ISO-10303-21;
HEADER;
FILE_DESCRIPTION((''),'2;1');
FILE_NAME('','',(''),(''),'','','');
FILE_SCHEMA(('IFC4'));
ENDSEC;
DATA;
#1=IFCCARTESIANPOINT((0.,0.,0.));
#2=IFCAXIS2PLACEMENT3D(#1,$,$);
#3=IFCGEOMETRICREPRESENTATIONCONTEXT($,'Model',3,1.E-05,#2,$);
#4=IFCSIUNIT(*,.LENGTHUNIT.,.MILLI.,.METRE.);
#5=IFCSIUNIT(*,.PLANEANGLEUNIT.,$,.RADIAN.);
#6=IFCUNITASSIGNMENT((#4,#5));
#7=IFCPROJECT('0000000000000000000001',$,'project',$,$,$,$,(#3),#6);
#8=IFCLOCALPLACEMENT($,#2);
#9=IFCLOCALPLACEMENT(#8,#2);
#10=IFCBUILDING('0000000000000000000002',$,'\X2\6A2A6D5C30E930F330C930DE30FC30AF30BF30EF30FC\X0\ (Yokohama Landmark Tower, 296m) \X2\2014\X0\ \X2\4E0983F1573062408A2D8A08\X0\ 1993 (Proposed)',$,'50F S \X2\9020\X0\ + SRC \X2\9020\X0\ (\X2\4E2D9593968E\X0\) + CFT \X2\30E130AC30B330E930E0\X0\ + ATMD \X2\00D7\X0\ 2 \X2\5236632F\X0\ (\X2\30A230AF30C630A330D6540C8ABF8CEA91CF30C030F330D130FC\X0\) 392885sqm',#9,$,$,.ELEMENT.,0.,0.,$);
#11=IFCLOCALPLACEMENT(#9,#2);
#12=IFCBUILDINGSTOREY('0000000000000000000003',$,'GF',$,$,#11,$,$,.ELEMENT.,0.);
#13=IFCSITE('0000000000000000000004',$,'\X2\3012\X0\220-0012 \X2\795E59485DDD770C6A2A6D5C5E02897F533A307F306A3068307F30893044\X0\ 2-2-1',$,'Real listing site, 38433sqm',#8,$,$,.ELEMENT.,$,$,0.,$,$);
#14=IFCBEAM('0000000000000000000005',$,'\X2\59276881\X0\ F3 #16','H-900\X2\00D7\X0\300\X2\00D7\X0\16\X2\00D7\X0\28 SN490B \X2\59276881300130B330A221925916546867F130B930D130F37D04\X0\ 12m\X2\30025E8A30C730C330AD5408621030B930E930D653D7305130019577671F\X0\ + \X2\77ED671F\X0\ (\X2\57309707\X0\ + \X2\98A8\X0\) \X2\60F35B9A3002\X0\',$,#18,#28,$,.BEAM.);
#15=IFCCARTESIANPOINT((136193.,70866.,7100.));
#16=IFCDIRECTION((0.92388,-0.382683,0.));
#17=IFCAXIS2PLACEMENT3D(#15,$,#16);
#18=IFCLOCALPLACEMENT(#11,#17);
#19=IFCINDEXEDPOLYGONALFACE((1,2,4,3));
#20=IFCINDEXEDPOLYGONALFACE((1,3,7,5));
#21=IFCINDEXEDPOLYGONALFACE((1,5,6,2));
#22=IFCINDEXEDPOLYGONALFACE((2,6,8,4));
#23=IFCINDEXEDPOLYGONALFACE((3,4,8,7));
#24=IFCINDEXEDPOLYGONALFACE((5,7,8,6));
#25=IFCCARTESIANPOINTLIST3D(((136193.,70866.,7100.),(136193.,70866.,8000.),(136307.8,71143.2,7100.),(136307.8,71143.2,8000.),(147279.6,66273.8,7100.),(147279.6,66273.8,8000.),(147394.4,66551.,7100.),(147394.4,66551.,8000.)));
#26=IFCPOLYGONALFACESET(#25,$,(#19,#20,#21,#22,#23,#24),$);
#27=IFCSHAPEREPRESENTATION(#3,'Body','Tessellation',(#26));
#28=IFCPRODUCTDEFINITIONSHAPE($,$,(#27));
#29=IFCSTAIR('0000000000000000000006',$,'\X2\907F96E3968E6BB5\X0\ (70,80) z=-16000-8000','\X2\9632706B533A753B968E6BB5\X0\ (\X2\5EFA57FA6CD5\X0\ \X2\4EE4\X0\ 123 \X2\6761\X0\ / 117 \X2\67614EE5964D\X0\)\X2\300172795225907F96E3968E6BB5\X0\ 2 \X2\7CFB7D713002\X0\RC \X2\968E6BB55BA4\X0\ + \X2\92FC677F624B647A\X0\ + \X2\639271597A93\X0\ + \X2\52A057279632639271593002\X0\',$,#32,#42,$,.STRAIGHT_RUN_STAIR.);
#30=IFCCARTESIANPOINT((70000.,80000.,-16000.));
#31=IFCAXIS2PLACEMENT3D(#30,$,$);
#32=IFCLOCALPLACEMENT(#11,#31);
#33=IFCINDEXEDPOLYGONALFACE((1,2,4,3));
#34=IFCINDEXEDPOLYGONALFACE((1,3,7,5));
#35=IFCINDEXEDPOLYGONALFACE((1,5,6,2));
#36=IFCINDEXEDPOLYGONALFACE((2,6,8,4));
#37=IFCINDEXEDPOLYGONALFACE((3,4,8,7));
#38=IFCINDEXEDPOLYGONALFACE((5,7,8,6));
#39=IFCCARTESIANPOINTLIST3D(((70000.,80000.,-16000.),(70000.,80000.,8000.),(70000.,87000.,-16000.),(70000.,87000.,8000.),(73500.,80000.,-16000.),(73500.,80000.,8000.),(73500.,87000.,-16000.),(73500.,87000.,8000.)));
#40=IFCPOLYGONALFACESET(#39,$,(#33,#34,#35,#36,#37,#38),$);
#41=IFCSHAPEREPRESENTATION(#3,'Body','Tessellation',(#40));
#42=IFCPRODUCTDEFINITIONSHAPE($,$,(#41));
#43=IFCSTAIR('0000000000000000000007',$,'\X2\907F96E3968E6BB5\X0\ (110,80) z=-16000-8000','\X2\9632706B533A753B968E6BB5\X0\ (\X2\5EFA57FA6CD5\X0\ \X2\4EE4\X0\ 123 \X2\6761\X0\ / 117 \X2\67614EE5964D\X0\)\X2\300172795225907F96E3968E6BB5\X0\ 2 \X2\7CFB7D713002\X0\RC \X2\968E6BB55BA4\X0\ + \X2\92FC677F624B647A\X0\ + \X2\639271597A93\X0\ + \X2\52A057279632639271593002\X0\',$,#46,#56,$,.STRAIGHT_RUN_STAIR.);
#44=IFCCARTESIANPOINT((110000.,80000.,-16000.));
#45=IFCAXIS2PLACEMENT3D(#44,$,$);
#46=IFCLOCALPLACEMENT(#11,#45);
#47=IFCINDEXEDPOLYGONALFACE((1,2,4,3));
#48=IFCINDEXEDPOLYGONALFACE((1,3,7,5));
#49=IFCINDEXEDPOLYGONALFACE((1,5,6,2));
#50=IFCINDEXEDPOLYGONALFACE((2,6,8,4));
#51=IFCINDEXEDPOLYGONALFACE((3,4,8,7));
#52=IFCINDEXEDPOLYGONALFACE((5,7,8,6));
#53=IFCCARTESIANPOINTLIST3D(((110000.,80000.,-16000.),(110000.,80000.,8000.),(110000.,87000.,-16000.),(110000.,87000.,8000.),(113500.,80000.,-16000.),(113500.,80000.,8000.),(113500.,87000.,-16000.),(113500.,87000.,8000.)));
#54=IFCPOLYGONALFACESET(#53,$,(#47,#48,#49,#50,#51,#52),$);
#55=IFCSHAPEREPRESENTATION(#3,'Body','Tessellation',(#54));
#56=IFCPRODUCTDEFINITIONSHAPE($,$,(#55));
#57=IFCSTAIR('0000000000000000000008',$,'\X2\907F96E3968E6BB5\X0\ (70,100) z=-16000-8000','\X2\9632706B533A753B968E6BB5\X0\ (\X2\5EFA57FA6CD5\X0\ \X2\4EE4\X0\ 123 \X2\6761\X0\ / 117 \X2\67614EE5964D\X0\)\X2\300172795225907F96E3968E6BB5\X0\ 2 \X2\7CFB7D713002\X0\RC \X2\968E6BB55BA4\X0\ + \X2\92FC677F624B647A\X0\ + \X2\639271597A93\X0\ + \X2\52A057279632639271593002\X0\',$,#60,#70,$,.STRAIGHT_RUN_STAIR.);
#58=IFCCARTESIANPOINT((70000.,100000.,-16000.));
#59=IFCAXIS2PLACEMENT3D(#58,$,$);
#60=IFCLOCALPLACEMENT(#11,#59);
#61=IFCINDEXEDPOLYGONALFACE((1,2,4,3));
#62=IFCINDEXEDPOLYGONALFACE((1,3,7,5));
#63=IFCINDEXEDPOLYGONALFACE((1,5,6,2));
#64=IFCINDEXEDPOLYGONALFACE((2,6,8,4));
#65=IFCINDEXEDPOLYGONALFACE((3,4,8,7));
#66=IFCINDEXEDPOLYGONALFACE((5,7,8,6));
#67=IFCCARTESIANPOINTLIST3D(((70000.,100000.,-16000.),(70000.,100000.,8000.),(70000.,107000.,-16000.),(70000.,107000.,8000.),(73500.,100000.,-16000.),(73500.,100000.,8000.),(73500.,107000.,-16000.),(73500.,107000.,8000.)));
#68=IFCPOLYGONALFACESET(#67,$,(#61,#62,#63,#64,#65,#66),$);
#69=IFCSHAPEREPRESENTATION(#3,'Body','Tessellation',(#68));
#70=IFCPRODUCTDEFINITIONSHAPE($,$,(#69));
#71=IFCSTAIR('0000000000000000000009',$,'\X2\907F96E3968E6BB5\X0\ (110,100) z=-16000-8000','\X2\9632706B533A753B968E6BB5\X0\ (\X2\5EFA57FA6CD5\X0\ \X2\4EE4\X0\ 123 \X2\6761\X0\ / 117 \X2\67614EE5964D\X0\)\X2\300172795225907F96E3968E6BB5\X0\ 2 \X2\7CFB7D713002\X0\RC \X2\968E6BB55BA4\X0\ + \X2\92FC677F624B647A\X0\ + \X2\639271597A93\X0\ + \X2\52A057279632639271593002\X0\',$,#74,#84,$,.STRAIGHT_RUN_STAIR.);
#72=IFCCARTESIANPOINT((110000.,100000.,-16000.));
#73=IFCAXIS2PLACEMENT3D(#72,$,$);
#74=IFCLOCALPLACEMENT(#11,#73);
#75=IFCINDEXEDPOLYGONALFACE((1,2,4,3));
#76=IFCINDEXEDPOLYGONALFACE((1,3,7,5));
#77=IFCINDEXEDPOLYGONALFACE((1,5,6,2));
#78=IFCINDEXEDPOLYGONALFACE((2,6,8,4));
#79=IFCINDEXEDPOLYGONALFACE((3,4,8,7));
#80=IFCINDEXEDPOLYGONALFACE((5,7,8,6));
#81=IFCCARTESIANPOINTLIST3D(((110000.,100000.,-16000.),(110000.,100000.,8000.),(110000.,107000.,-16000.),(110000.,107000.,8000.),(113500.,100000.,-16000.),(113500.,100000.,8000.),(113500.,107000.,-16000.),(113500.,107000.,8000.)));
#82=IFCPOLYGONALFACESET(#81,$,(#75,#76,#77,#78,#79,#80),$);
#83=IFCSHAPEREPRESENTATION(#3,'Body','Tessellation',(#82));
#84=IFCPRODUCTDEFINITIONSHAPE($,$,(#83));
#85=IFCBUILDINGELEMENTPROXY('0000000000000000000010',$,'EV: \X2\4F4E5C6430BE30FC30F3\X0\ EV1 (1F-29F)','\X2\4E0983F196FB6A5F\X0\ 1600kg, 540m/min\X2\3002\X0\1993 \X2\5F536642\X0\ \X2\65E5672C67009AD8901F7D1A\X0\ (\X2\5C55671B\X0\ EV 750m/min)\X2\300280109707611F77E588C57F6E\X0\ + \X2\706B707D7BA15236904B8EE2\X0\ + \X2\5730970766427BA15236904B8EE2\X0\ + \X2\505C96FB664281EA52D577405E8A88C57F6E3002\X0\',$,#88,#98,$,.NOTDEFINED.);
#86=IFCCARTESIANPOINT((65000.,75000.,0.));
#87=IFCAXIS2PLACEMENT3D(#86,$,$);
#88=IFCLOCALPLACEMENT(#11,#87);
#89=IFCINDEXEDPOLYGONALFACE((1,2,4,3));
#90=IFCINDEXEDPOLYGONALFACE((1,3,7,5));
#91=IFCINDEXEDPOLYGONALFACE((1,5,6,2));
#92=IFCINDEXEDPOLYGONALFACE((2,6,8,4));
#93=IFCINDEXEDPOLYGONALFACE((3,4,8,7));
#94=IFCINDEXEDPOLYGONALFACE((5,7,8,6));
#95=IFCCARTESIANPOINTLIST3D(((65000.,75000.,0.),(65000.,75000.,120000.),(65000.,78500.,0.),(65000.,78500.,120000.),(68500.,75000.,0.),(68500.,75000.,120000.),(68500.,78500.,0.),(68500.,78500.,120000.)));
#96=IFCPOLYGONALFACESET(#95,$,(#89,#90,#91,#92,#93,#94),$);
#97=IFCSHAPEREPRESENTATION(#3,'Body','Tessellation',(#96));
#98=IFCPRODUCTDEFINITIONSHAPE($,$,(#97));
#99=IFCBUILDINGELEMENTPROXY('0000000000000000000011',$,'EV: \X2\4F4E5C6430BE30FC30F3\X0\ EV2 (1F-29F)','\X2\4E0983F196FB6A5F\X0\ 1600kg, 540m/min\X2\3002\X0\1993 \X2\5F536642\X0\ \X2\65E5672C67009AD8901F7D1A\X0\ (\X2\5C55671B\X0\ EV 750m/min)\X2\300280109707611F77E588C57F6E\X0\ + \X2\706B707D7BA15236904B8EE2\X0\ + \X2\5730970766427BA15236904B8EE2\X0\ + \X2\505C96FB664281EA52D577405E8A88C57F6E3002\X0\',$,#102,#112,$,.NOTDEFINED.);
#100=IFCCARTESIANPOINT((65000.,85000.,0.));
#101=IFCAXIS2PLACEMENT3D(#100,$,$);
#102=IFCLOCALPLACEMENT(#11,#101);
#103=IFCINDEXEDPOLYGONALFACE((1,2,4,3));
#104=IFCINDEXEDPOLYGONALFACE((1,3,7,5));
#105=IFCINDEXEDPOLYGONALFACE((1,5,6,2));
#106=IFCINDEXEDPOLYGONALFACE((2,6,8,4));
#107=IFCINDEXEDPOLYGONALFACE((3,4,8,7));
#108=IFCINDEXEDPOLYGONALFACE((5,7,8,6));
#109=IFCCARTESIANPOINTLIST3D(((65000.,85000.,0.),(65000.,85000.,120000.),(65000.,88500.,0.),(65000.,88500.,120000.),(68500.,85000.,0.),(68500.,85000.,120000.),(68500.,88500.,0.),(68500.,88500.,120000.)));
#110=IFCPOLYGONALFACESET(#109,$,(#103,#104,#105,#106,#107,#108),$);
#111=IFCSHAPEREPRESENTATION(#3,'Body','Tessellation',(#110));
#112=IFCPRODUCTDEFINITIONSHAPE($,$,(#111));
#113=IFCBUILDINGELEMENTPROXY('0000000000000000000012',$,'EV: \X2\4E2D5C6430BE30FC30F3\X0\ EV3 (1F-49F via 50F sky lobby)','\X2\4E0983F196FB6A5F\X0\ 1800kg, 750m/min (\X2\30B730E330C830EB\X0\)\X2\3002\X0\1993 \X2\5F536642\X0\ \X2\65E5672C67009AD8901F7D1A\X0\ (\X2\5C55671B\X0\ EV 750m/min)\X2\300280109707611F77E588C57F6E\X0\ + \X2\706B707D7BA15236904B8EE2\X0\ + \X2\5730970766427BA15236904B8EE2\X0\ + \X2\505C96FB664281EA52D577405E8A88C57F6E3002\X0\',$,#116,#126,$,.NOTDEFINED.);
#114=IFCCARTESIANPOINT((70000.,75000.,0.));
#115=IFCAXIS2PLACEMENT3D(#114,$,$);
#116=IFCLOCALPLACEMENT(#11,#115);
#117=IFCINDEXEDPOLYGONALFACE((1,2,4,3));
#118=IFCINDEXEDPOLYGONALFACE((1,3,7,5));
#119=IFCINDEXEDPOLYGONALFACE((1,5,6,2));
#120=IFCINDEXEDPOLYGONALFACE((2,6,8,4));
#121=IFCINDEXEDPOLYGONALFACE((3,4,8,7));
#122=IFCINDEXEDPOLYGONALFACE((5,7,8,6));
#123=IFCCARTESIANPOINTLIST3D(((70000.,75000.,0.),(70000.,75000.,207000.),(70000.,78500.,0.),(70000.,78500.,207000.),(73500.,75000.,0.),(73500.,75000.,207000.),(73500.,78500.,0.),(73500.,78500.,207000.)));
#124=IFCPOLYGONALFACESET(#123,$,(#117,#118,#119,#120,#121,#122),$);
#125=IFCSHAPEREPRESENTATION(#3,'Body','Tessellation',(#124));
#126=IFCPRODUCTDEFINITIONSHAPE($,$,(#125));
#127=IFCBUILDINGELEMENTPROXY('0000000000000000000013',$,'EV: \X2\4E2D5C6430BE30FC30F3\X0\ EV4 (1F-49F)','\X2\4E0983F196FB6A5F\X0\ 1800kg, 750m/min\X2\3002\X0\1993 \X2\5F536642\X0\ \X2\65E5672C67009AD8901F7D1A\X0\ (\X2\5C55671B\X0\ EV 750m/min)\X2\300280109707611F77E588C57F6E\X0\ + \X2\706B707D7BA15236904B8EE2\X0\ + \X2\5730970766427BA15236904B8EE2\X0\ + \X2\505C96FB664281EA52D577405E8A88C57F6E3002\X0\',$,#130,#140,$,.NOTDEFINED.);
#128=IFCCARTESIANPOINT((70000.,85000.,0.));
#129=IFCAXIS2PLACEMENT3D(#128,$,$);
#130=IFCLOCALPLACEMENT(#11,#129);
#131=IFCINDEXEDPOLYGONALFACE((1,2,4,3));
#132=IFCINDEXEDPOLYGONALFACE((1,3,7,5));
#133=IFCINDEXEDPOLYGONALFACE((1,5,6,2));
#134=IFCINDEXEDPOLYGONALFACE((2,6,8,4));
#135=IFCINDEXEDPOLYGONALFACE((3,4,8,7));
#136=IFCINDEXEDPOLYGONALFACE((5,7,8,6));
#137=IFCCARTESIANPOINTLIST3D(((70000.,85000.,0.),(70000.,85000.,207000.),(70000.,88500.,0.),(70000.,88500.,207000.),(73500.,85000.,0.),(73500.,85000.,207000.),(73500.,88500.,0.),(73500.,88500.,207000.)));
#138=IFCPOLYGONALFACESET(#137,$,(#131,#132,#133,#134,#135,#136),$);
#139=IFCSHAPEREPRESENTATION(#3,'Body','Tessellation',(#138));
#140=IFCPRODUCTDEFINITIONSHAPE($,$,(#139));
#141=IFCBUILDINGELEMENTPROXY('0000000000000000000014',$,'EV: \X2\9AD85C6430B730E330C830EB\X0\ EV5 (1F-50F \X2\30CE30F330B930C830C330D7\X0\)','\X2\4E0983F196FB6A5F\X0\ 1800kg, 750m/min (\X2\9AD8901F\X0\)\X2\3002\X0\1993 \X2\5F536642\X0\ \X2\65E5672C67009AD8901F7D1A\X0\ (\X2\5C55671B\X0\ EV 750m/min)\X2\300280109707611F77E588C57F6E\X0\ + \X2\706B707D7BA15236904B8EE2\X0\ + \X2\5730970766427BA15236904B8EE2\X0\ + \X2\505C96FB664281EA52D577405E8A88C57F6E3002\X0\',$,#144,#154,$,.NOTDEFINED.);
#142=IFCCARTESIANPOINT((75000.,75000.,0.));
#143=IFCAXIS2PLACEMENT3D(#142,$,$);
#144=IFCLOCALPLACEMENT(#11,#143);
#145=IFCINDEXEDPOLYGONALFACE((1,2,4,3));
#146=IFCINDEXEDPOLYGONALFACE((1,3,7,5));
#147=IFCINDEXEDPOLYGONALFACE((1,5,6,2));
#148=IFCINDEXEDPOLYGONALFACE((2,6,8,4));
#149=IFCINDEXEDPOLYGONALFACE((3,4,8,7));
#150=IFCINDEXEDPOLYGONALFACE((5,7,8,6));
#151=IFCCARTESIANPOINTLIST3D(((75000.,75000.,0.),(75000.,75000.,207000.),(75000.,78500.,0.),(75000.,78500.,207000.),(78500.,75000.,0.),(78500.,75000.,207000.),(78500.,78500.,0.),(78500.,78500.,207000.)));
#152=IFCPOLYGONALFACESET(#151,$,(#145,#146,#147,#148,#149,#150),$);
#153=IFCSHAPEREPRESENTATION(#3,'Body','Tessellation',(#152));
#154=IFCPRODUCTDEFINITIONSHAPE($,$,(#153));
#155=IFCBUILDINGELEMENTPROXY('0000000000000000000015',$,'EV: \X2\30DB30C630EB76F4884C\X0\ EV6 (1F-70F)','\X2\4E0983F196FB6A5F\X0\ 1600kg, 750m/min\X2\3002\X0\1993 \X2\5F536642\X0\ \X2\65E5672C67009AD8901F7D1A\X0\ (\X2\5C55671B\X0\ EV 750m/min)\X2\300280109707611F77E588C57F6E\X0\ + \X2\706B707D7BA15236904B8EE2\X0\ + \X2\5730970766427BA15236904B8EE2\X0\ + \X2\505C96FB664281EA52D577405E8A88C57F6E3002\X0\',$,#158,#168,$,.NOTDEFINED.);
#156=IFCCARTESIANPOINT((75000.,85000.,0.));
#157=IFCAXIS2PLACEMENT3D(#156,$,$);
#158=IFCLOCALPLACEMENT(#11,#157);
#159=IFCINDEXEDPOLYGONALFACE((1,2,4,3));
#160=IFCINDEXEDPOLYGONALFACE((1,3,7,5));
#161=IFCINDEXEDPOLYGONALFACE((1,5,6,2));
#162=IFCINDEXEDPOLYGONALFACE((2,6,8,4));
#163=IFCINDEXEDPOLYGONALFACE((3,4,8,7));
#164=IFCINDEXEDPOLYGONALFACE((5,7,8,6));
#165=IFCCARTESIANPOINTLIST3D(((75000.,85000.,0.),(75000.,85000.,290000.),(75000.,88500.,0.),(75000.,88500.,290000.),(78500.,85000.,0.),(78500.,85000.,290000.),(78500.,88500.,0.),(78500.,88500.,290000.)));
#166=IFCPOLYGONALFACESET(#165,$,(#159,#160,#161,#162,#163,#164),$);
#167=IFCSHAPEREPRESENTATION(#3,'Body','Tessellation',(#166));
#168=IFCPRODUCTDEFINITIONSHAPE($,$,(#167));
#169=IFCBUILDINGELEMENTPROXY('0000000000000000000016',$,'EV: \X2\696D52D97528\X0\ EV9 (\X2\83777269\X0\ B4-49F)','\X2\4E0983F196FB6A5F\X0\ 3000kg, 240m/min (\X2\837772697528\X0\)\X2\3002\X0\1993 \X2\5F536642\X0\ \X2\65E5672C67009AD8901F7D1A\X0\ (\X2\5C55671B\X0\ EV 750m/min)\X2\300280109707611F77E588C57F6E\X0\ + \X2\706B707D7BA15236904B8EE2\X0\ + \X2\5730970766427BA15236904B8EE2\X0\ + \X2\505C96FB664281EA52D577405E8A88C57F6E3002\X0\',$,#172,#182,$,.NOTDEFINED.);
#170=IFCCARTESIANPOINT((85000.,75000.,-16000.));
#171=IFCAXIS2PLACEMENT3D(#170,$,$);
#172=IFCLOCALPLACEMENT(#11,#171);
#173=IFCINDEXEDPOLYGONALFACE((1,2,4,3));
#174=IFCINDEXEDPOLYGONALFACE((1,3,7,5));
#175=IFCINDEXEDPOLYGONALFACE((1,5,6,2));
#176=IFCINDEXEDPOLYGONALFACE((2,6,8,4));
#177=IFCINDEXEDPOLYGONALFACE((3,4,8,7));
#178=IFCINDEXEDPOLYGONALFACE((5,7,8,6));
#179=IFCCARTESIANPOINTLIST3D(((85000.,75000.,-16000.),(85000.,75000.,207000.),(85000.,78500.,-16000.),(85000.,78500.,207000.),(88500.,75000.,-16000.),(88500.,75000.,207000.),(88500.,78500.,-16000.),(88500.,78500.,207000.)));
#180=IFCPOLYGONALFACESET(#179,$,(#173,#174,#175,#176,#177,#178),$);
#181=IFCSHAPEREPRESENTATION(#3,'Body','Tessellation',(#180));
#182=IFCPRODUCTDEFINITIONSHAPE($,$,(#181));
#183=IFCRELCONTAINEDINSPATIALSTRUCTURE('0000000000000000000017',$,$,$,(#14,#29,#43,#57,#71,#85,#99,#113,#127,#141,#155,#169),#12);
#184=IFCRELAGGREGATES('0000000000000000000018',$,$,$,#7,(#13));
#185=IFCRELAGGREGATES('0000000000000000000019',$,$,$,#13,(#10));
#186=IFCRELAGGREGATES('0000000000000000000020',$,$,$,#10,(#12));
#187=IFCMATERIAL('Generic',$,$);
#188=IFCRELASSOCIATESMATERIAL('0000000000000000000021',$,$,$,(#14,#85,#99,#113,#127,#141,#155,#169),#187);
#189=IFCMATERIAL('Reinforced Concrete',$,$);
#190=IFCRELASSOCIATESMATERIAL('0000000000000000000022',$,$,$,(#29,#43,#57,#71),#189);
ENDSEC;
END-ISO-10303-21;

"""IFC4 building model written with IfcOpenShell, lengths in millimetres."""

from ifc_helpers import new_model, si_unit, frame, frame_2d, origin, place, context, project, spatial, rectangle, extrude, material, element, save


model = new_model("IFC4")

# Units and contexts
model_context = context("Model", 3, precision=1e-05, world=origin())
ifc_project = project(units=[si_unit("LENGTHUNIT", "METRE", prefix="MILLI"), si_unit("PLANEANGLEUNIT", "RADIAN")], contexts=[model_context])

# Site, building, storey
site_placement = place(None, origin())
site = spatial("IfcSite", under=ifc_project, at=site_placement, Name="〒220-0012 神奈川県横浜市西区みなとみらい 2-2-1", ObjectType="Real listing site, 38433sqm", CompositionType="ELEMENT", RefElevation=0.0)
building_placement = place(site_placement, origin())
building = spatial("IfcBuilding", under=site, at=building_placement, Name="横浜ランドマークタワー (Yokohama Landmark Tower, 296m) — 三菱地所設計 1993 (Proposed)", ObjectType="50F S 造 + SRC 造 (中間階) + CFT メガコラム + ATMD × 2 制振 (アクティブ同調質量ダンパー) 392885sqm", CompositionType="ELEMENT", ElevationOfRefHeight=0.0, ElevationOfTerrain=0.0)
storey_placement = place(building_placement, origin())
storey = spatial("IfcBuildingStorey", under=building, at=storey_placement, Name="GF", CompositionType="ELEMENT", Elevation=0.0)

# Shared definitions
ifc_material_1 = material(Name="Reinforced Concrete")

# Beam
ifc_material_2 = material(Name="Generic")
beam_1_placement = place(storey_placement, frame((136193.0, 70866.0, 7100.0), x_axis=(0.92388, -0.382683, 0.0)))
element("IfcBeam", 1, at=beam_1_placement, inside=storey, material=ifc_material_2, Name="大梁 F3 #16", Description="H-900×300×16×28 SN490B 大梁、コア→外周柱スパン約 12m。床デッキ合成スラブ受け、長期 + 短期 (地震 + 風) 想定。", PredefinedType="BEAM", context=model_context, shape_type="SweptSolid", body=[
    extrude(rectangle(XDim=12000.0, YDim=300.0, at=frame_2d((6000.0, 150.0))), frame((136193.0, 70866.0, 7100.0), x_axis=(0.92388, -0.382683, 0.0)), (0.0, 0.0, 1.0), 900.0),
])

# Stairs
stair_1_placement = place(storey_placement, frame((70000.0, 80000.0, -16000.0)))
element("IfcStair", 2, at=stair_1_placement, inside=storey, material=ifc_material_1, Name="避難階段 (70,80) z=-16000-8000", Description="防火区画階段 (建基法 令 123 条 / 117 条以降)、特別避難階段 2 系統。RC 階段室 + 鋼板手摺 + 排煙窓 + 加圧防排煙。", PredefinedType="STRAIGHT_RUN_STAIR", context=model_context, shape_type="SweptSolid", body=[
    extrude(rectangle(XDim=3500.0, YDim=7000.0, at=frame_2d((1750.0, 3500.0))), frame((70000.0, 80000.0, -16000.0)), (0.0, 0.0, 1.0), 24000.0),
])
stair_2_placement = place(storey_placement, frame((110000.0, 80000.0, -16000.0)))
element("IfcStair", 3, at=stair_2_placement, inside=storey, material=ifc_material_1, Name="避難階段 (110,80) z=-16000-8000", Description="防火区画階段 (建基法 令 123 条 / 117 条以降)、特別避難階段 2 系統。RC 階段室 + 鋼板手摺 + 排煙窓 + 加圧防排煙。", PredefinedType="STRAIGHT_RUN_STAIR", context=model_context, shape_type="SweptSolid", body=[
    extrude(rectangle(XDim=3500.0, YDim=7000.0, at=frame_2d((1750.0, 3500.0))), frame((110000.0, 80000.0, -16000.0)), (0.0, 0.0, 1.0), 24000.0),
])
stair_3_placement = place(storey_placement, frame((70000.0, 100000.0, -16000.0)))
element("IfcStair", 4, at=stair_3_placement, inside=storey, material=ifc_material_1, Name="避難階段 (70,100) z=-16000-8000", Description="防火区画階段 (建基法 令 123 条 / 117 条以降)、特別避難階段 2 系統。RC 階段室 + 鋼板手摺 + 排煙窓 + 加圧防排煙。", PredefinedType="STRAIGHT_RUN_STAIR", context=model_context, shape_type="SweptSolid", body=[
    extrude(rectangle(XDim=3500.0, YDim=7000.0, at=frame_2d((1750.0, 3500.0))), frame((70000.0, 100000.0, -16000.0)), (0.0, 0.0, 1.0), 24000.0),
])
stair_4_placement = place(storey_placement, frame((110000.0, 100000.0, -16000.0)))
element("IfcStair", 5, at=stair_4_placement, inside=storey, material=ifc_material_1, Name="避難階段 (110,100) z=-16000-8000", Description="防火区画階段 (建基法 令 123 条 / 117 条以降)、特別避難階段 2 系統。RC 階段室 + 鋼板手摺 + 排煙窓 + 加圧防排煙。", PredefinedType="STRAIGHT_RUN_STAIR", context=model_context, shape_type="SweptSolid", body=[
    extrude(rectangle(XDim=3500.0, YDim=7000.0, at=frame_2d((1750.0, 3500.0))), frame((110000.0, 100000.0, -16000.0)), (0.0, 0.0, 1.0), 24000.0),
])

# Building element proxies
proxy_1_placement = place(storey_placement, frame((65000.0, 75000.0, 0.0)))
element("IfcBuildingElementProxy", 6, at=proxy_1_placement, inside=storey, material=ifc_material_2, Name="EV: 低層ゾーン EV1 (1F-29F)", Description="三菱電機 1600kg, 540m/min。1993 当時 日本最高速級 (展望 EV 750m/min)。耐震感知装置 + 火災管制運転 + 地震時管制運転 + 停電時自動着床装置。", PredefinedType="NOTDEFINED", context=model_context, shape_type="SweptSolid", body=[
    extrude(rectangle(XDim=3500.0, YDim=3500.0, at=frame_2d((1750.0, 1750.0))), frame((65000.0, 75000.0, 0.0)), (0.0, 0.0, 1.0), 120000.0),
])
proxy_2_placement = place(storey_placement, frame((65000.0, 85000.0, 0.0)))
element("IfcBuildingElementProxy", 7, at=proxy_2_placement, inside=storey, material=ifc_material_2, Name="EV: 低層ゾーン EV2 (1F-29F)", Description="三菱電機 1600kg, 540m/min。1993 当時 日本最高速級 (展望 EV 750m/min)。耐震感知装置 + 火災管制運転 + 地震時管制運転 + 停電時自動着床装置。", PredefinedType="NOTDEFINED", context=model_context, shape_type="SweptSolid", body=[
    extrude(rectangle(XDim=3500.0, YDim=3500.0, at=frame_2d((1750.0, 1750.0))), frame((65000.0, 85000.0, 0.0)), (0.0, 0.0, 1.0), 120000.0),
])
proxy_3_placement = place(storey_placement, frame((70000.0, 75000.0, 0.0)))
element("IfcBuildingElementProxy", 8, at=proxy_3_placement, inside=storey, material=ifc_material_2, Name="EV: 中層ゾーン EV3 (1F-49F via 50F sky lobby)", Description="三菱電機 1800kg, 750m/min (シャトル)。1993 当時 日本最高速級 (展望 EV 750m/min)。耐震感知装置 + 火災管制運転 + 地震時管制運転 + 停電時自動着床装置。", PredefinedType="NOTDEFINED", context=model_context, shape_type="SweptSolid", body=[
    extrude(rectangle(XDim=3500.0, YDim=3500.0, at=frame_2d((1750.0, 1750.0))), frame((70000.0, 75000.0, 0.0)), (0.0, 0.0, 1.0), 207000.0),
])
proxy_4_placement = place(storey_placement, frame((70000.0, 85000.0, 0.0)))
element("IfcBuildingElementProxy", 9, at=proxy_4_placement, inside=storey, material=ifc_material_2, Name="EV: 中層ゾーン EV4 (1F-49F)", Description="三菱電機 1800kg, 750m/min。1993 当時 日本最高速級 (展望 EV 750m/min)。耐震感知装置 + 火災管制運転 + 地震時管制運転 + 停電時自動着床装置。", PredefinedType="NOTDEFINED", context=model_context, shape_type="SweptSolid", body=[
    extrude(rectangle(XDim=3500.0, YDim=3500.0, at=frame_2d((1750.0, 1750.0))), frame((70000.0, 85000.0, 0.0)), (0.0, 0.0, 1.0), 207000.0),
])
proxy_5_placement = place(storey_placement, frame((75000.0, 75000.0, 0.0)))
element("IfcBuildingElementProxy", 10, at=proxy_5_placement, inside=storey, material=ifc_material_2, Name="EV: 高層シャトル EV5 (1F-50F ノンストップ)", Description="三菱電機 1800kg, 750m/min (高速)。1993 当時 日本最高速級 (展望 EV 750m/min)。耐震感知装置 + 火災管制運転 + 地震時管制運転 + 停電時自動着床装置。", PredefinedType="NOTDEFINED", context=model_context, shape_type="SweptSolid", body=[
    extrude(rectangle(XDim=3500.0, YDim=3500.0, at=frame_2d((1750.0, 1750.0))), frame((75000.0, 75000.0, 0.0)), (0.0, 0.0, 1.0), 207000.0),
])
proxy_6_placement = place(storey_placement, frame((75000.0, 85000.0, 0.0)))
element("IfcBuildingElementProxy", 11, at=proxy_6_placement, inside=storey, material=ifc_material_2, Name="EV: ホテル直行 EV6 (1F-70F)", Description="三菱電機 1600kg, 750m/min。1993 当時 日本最高速級 (展望 EV 750m/min)。耐震感知装置 + 火災管制運転 + 地震時管制運転 + 停電時自動着床装置。", PredefinedType="NOTDEFINED", context=model_context, shape_type="SweptSolid", body=[
    extrude(rectangle(XDim=3500.0, YDim=3500.0, at=frame_2d((1750.0, 1750.0))), frame((75000.0, 85000.0, 0.0)), (0.0, 0.0, 1.0), 290000.0),
])
proxy_7_placement = place(storey_placement, frame((85000.0, 75000.0, -16000.0)))
element("IfcBuildingElementProxy", 12, at=proxy_7_placement, inside=storey, material=ifc_material_2, Name="EV: 業務用 EV9 (荷物 B4-49F)", Description="三菱電機 3000kg, 240m/min (荷物用)。1993 当時 日本最高速級 (展望 EV 750m/min)。耐震感知装置 + 火災管制運転 + 地震時管制運転 + 停電時自動着床装置。", PredefinedType="NOTDEFINED", context=model_context, shape_type="SweptSolid", body=[
    extrude(rectangle(XDim=3500.0, YDim=3500.0, at=frame_2d((1750.0, 1750.0))), frame((85000.0, 75000.0, -16000.0)), (0.0, 0.0, 1.0), 223000.0),
])

save(model, "model.ifc")
